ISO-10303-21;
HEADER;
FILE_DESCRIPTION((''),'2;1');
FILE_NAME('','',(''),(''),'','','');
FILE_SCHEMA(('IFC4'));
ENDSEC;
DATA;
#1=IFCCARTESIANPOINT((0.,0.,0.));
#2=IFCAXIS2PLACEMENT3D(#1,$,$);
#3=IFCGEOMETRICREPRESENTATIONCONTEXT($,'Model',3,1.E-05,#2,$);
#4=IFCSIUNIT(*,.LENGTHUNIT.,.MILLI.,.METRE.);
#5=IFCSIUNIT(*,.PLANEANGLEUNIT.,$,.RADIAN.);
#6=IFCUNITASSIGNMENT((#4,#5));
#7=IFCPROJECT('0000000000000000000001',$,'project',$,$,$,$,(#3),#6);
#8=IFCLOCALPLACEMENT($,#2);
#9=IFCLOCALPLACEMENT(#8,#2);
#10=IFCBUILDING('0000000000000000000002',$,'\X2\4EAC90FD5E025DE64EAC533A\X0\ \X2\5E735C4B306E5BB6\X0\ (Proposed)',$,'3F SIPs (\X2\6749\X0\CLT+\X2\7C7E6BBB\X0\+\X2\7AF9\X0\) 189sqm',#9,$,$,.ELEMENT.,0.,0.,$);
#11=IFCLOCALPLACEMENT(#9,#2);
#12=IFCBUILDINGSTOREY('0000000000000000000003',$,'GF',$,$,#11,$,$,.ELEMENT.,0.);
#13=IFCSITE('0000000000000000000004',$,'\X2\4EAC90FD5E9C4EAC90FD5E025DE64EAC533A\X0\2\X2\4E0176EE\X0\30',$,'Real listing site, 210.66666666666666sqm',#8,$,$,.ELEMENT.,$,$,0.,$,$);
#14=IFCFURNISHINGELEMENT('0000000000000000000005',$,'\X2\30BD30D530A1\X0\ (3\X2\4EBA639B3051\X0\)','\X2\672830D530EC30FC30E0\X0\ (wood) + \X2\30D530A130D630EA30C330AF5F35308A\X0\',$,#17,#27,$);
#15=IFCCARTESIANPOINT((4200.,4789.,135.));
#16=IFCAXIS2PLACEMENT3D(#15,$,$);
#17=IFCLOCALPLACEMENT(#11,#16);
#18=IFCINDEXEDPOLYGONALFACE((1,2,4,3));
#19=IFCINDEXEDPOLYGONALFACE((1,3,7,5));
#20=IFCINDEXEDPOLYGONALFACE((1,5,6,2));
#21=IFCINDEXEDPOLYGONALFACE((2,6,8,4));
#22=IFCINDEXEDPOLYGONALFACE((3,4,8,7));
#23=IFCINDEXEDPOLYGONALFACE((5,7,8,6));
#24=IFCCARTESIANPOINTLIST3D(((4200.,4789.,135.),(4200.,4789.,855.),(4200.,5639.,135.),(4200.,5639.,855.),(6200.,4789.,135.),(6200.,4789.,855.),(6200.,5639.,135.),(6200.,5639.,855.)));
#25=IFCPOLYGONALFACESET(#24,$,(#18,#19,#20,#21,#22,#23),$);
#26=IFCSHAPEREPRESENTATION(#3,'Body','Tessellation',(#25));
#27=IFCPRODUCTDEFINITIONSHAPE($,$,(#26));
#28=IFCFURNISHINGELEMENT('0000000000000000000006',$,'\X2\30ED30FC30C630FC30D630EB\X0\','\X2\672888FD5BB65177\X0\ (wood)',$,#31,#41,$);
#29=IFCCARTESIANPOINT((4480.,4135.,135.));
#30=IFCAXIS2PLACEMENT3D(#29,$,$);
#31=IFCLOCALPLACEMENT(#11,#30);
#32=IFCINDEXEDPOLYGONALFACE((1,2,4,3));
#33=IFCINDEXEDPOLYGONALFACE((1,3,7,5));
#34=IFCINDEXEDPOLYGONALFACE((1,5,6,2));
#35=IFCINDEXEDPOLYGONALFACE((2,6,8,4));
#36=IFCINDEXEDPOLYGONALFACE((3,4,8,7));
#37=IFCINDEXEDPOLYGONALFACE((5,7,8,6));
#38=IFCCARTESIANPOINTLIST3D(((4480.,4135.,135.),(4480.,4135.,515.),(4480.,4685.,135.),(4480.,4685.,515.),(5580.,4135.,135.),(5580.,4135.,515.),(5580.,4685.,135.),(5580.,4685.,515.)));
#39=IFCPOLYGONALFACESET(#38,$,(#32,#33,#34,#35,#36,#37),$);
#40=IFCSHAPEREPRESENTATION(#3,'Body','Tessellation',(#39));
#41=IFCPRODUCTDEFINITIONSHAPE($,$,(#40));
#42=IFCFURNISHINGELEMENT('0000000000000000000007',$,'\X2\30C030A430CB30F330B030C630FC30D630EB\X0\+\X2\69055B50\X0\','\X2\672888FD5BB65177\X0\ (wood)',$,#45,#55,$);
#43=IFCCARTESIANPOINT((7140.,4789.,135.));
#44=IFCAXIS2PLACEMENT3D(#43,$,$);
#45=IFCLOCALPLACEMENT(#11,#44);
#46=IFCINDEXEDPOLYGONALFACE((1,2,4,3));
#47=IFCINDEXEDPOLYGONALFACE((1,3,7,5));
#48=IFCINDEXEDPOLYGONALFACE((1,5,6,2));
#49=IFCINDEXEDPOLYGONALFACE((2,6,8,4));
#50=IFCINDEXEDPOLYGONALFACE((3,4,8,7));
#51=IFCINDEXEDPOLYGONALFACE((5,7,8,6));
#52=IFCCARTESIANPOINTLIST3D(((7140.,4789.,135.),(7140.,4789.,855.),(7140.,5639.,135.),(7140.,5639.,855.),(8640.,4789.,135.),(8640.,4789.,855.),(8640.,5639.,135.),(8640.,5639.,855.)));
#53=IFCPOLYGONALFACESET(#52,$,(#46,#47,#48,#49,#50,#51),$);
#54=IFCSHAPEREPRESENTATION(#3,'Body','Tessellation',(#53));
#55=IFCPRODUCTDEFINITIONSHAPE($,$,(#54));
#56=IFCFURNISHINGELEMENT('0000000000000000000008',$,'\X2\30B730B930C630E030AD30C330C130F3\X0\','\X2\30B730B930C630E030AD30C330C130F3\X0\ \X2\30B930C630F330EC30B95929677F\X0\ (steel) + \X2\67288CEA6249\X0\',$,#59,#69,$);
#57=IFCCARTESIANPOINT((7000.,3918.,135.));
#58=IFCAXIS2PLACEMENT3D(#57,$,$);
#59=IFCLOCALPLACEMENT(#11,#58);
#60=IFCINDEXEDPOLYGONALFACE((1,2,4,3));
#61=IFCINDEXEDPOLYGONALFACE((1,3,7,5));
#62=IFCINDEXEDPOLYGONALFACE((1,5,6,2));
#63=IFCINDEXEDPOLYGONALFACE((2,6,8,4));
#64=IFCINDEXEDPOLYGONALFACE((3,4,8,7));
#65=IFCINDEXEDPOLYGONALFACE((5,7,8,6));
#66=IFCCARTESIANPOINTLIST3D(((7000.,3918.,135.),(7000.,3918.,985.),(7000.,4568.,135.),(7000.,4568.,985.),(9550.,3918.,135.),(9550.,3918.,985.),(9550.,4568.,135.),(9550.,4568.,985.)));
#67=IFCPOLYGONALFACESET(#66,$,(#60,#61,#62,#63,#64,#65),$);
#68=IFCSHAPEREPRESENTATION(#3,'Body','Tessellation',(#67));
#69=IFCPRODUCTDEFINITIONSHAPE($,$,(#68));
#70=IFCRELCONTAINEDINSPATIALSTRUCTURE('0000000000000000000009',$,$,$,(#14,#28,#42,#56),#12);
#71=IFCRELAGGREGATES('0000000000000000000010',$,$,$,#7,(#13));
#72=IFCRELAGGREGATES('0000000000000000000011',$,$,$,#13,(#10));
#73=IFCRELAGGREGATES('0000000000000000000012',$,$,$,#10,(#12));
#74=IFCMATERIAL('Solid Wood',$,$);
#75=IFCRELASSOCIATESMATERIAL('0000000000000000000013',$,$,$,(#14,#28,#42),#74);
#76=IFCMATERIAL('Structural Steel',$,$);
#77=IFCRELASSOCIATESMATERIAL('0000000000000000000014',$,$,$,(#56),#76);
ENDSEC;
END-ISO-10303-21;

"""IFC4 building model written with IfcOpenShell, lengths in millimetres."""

from ifc_helpers import new_model, si_unit, frame, frame_2d, origin, place, context, project, spatial, rectangle, extrude, material, element, save


model = new_model("IFC4")

# Units and contexts
model_context = context("Model", 3, precision=1e-05, world=origin())
ifc_project = project(units=[si_unit("LENGTHUNIT", "METRE", prefix="MILLI"), si_unit("PLANEANGLEUNIT", "RADIAN")], contexts=[model_context])

# Site, building, storey
site_placement = place(None, origin())
site = spatial("IfcSite", under=ifc_project, at=site_placement, Name="京都府京都市左京区2丁目30", ObjectType="Real listing site, 210.66666666666666sqm", CompositionType="ELEMENT", RefElevation=0.0)
building_placement = place(site_placement, origin())
building = spatial("IfcBuilding", under=site, at=building_placement, Name="京都市左京区 平屋の家 (Proposed)", ObjectType="3F SIPs (杉CLT+籾殻+竹) 189sqm", CompositionType="ELEMENT", ElevationOfRefHeight=0.0, ElevationOfTerrain=0.0)
storey_placement = place(building_placement, origin())
storey = spatial("IfcBuildingStorey", under=building, at=storey_placement, Name="GF", CompositionType="ELEMENT", Elevation=0.0)

# Shared definitions
ifc_material_1 = material(Name="Solid Wood")

# Furnishing elements
furnishing_1_placement = place(storey_placement, frame((4200.0, 4789.0, 135.0)))
element("IfcFurnishingElement", 1, at=furnishing_1_placement, inside=storey, material=ifc_material_1, Name="ソファ (3人掛け)", Description="木フレーム (wood) + ファブリック張り", context=model_context, shape_type="SweptSolid", body=[
    extrude(rectangle(XDim=2000.0, YDim=850.0, at=frame_2d((1000.0, 425.0))), frame((4200.0, 4789.0, 135.0)), (0.0, 0.0, 1.0), 720.0),
])
furnishing_2_placement = place(storey_placement, frame((4480.0, 4135.0, 135.0)))
element("IfcFurnishingElement", 2, at=furnishing_2_placement, inside=storey, material=ifc_material_1, Name="ローテーブル", Description="木製家具 (wood)", context=model_context, shape_type="SweptSolid", body=[
    extrude(rectangle(XDim=1100.0, YDim=550.0, at=frame_2d((550.0, 275.0))), frame((4480.0, 4135.0, 135.0)), (0.0, 0.0, 1.0), 380.0),
])
furnishing_3_placement = place(storey_placement, frame((7140.0, 4789.0, 135.0)))
element("IfcFurnishingElement", 3, at=furnishing_3_placement, inside=storey, material=ifc_material_1, Name="ダイニングテーブル+椅子", Description="木製家具 (wood)", context=model_context, shape_type="SweptSolid", body=[
    extrude(rectangle(XDim=1500.0, YDim=850.0, at=frame_2d((750.0, 425.0))), frame((7140.0, 4789.0, 135.0)), (0.0, 0.0, 1.0), 720.0),
])
ifc_material_2 = material(Name="Structural Steel")
furnishing_4_placement = place(storey_placement, frame((7000.0, 3918.0, 135.0)))
element("IfcFurnishingElement", 4, at=furnishing_4_placement, inside=storey, material=ifc_material_2, Name="システムキッチン", Description="システムキッチン ステンレス天板 (steel) + 木質扉", context=model_context, shape_type="SweptSolid", body=[
    extrude(rectangle(XDim=2550.0, YDim=650.0, at=frame_2d((1275.0, 325.0))), frame((7000.0, 3918.0, 135.0)), (0.0, 0.0, 1.0), 850.0),
])

save(model, "model.ifc")
